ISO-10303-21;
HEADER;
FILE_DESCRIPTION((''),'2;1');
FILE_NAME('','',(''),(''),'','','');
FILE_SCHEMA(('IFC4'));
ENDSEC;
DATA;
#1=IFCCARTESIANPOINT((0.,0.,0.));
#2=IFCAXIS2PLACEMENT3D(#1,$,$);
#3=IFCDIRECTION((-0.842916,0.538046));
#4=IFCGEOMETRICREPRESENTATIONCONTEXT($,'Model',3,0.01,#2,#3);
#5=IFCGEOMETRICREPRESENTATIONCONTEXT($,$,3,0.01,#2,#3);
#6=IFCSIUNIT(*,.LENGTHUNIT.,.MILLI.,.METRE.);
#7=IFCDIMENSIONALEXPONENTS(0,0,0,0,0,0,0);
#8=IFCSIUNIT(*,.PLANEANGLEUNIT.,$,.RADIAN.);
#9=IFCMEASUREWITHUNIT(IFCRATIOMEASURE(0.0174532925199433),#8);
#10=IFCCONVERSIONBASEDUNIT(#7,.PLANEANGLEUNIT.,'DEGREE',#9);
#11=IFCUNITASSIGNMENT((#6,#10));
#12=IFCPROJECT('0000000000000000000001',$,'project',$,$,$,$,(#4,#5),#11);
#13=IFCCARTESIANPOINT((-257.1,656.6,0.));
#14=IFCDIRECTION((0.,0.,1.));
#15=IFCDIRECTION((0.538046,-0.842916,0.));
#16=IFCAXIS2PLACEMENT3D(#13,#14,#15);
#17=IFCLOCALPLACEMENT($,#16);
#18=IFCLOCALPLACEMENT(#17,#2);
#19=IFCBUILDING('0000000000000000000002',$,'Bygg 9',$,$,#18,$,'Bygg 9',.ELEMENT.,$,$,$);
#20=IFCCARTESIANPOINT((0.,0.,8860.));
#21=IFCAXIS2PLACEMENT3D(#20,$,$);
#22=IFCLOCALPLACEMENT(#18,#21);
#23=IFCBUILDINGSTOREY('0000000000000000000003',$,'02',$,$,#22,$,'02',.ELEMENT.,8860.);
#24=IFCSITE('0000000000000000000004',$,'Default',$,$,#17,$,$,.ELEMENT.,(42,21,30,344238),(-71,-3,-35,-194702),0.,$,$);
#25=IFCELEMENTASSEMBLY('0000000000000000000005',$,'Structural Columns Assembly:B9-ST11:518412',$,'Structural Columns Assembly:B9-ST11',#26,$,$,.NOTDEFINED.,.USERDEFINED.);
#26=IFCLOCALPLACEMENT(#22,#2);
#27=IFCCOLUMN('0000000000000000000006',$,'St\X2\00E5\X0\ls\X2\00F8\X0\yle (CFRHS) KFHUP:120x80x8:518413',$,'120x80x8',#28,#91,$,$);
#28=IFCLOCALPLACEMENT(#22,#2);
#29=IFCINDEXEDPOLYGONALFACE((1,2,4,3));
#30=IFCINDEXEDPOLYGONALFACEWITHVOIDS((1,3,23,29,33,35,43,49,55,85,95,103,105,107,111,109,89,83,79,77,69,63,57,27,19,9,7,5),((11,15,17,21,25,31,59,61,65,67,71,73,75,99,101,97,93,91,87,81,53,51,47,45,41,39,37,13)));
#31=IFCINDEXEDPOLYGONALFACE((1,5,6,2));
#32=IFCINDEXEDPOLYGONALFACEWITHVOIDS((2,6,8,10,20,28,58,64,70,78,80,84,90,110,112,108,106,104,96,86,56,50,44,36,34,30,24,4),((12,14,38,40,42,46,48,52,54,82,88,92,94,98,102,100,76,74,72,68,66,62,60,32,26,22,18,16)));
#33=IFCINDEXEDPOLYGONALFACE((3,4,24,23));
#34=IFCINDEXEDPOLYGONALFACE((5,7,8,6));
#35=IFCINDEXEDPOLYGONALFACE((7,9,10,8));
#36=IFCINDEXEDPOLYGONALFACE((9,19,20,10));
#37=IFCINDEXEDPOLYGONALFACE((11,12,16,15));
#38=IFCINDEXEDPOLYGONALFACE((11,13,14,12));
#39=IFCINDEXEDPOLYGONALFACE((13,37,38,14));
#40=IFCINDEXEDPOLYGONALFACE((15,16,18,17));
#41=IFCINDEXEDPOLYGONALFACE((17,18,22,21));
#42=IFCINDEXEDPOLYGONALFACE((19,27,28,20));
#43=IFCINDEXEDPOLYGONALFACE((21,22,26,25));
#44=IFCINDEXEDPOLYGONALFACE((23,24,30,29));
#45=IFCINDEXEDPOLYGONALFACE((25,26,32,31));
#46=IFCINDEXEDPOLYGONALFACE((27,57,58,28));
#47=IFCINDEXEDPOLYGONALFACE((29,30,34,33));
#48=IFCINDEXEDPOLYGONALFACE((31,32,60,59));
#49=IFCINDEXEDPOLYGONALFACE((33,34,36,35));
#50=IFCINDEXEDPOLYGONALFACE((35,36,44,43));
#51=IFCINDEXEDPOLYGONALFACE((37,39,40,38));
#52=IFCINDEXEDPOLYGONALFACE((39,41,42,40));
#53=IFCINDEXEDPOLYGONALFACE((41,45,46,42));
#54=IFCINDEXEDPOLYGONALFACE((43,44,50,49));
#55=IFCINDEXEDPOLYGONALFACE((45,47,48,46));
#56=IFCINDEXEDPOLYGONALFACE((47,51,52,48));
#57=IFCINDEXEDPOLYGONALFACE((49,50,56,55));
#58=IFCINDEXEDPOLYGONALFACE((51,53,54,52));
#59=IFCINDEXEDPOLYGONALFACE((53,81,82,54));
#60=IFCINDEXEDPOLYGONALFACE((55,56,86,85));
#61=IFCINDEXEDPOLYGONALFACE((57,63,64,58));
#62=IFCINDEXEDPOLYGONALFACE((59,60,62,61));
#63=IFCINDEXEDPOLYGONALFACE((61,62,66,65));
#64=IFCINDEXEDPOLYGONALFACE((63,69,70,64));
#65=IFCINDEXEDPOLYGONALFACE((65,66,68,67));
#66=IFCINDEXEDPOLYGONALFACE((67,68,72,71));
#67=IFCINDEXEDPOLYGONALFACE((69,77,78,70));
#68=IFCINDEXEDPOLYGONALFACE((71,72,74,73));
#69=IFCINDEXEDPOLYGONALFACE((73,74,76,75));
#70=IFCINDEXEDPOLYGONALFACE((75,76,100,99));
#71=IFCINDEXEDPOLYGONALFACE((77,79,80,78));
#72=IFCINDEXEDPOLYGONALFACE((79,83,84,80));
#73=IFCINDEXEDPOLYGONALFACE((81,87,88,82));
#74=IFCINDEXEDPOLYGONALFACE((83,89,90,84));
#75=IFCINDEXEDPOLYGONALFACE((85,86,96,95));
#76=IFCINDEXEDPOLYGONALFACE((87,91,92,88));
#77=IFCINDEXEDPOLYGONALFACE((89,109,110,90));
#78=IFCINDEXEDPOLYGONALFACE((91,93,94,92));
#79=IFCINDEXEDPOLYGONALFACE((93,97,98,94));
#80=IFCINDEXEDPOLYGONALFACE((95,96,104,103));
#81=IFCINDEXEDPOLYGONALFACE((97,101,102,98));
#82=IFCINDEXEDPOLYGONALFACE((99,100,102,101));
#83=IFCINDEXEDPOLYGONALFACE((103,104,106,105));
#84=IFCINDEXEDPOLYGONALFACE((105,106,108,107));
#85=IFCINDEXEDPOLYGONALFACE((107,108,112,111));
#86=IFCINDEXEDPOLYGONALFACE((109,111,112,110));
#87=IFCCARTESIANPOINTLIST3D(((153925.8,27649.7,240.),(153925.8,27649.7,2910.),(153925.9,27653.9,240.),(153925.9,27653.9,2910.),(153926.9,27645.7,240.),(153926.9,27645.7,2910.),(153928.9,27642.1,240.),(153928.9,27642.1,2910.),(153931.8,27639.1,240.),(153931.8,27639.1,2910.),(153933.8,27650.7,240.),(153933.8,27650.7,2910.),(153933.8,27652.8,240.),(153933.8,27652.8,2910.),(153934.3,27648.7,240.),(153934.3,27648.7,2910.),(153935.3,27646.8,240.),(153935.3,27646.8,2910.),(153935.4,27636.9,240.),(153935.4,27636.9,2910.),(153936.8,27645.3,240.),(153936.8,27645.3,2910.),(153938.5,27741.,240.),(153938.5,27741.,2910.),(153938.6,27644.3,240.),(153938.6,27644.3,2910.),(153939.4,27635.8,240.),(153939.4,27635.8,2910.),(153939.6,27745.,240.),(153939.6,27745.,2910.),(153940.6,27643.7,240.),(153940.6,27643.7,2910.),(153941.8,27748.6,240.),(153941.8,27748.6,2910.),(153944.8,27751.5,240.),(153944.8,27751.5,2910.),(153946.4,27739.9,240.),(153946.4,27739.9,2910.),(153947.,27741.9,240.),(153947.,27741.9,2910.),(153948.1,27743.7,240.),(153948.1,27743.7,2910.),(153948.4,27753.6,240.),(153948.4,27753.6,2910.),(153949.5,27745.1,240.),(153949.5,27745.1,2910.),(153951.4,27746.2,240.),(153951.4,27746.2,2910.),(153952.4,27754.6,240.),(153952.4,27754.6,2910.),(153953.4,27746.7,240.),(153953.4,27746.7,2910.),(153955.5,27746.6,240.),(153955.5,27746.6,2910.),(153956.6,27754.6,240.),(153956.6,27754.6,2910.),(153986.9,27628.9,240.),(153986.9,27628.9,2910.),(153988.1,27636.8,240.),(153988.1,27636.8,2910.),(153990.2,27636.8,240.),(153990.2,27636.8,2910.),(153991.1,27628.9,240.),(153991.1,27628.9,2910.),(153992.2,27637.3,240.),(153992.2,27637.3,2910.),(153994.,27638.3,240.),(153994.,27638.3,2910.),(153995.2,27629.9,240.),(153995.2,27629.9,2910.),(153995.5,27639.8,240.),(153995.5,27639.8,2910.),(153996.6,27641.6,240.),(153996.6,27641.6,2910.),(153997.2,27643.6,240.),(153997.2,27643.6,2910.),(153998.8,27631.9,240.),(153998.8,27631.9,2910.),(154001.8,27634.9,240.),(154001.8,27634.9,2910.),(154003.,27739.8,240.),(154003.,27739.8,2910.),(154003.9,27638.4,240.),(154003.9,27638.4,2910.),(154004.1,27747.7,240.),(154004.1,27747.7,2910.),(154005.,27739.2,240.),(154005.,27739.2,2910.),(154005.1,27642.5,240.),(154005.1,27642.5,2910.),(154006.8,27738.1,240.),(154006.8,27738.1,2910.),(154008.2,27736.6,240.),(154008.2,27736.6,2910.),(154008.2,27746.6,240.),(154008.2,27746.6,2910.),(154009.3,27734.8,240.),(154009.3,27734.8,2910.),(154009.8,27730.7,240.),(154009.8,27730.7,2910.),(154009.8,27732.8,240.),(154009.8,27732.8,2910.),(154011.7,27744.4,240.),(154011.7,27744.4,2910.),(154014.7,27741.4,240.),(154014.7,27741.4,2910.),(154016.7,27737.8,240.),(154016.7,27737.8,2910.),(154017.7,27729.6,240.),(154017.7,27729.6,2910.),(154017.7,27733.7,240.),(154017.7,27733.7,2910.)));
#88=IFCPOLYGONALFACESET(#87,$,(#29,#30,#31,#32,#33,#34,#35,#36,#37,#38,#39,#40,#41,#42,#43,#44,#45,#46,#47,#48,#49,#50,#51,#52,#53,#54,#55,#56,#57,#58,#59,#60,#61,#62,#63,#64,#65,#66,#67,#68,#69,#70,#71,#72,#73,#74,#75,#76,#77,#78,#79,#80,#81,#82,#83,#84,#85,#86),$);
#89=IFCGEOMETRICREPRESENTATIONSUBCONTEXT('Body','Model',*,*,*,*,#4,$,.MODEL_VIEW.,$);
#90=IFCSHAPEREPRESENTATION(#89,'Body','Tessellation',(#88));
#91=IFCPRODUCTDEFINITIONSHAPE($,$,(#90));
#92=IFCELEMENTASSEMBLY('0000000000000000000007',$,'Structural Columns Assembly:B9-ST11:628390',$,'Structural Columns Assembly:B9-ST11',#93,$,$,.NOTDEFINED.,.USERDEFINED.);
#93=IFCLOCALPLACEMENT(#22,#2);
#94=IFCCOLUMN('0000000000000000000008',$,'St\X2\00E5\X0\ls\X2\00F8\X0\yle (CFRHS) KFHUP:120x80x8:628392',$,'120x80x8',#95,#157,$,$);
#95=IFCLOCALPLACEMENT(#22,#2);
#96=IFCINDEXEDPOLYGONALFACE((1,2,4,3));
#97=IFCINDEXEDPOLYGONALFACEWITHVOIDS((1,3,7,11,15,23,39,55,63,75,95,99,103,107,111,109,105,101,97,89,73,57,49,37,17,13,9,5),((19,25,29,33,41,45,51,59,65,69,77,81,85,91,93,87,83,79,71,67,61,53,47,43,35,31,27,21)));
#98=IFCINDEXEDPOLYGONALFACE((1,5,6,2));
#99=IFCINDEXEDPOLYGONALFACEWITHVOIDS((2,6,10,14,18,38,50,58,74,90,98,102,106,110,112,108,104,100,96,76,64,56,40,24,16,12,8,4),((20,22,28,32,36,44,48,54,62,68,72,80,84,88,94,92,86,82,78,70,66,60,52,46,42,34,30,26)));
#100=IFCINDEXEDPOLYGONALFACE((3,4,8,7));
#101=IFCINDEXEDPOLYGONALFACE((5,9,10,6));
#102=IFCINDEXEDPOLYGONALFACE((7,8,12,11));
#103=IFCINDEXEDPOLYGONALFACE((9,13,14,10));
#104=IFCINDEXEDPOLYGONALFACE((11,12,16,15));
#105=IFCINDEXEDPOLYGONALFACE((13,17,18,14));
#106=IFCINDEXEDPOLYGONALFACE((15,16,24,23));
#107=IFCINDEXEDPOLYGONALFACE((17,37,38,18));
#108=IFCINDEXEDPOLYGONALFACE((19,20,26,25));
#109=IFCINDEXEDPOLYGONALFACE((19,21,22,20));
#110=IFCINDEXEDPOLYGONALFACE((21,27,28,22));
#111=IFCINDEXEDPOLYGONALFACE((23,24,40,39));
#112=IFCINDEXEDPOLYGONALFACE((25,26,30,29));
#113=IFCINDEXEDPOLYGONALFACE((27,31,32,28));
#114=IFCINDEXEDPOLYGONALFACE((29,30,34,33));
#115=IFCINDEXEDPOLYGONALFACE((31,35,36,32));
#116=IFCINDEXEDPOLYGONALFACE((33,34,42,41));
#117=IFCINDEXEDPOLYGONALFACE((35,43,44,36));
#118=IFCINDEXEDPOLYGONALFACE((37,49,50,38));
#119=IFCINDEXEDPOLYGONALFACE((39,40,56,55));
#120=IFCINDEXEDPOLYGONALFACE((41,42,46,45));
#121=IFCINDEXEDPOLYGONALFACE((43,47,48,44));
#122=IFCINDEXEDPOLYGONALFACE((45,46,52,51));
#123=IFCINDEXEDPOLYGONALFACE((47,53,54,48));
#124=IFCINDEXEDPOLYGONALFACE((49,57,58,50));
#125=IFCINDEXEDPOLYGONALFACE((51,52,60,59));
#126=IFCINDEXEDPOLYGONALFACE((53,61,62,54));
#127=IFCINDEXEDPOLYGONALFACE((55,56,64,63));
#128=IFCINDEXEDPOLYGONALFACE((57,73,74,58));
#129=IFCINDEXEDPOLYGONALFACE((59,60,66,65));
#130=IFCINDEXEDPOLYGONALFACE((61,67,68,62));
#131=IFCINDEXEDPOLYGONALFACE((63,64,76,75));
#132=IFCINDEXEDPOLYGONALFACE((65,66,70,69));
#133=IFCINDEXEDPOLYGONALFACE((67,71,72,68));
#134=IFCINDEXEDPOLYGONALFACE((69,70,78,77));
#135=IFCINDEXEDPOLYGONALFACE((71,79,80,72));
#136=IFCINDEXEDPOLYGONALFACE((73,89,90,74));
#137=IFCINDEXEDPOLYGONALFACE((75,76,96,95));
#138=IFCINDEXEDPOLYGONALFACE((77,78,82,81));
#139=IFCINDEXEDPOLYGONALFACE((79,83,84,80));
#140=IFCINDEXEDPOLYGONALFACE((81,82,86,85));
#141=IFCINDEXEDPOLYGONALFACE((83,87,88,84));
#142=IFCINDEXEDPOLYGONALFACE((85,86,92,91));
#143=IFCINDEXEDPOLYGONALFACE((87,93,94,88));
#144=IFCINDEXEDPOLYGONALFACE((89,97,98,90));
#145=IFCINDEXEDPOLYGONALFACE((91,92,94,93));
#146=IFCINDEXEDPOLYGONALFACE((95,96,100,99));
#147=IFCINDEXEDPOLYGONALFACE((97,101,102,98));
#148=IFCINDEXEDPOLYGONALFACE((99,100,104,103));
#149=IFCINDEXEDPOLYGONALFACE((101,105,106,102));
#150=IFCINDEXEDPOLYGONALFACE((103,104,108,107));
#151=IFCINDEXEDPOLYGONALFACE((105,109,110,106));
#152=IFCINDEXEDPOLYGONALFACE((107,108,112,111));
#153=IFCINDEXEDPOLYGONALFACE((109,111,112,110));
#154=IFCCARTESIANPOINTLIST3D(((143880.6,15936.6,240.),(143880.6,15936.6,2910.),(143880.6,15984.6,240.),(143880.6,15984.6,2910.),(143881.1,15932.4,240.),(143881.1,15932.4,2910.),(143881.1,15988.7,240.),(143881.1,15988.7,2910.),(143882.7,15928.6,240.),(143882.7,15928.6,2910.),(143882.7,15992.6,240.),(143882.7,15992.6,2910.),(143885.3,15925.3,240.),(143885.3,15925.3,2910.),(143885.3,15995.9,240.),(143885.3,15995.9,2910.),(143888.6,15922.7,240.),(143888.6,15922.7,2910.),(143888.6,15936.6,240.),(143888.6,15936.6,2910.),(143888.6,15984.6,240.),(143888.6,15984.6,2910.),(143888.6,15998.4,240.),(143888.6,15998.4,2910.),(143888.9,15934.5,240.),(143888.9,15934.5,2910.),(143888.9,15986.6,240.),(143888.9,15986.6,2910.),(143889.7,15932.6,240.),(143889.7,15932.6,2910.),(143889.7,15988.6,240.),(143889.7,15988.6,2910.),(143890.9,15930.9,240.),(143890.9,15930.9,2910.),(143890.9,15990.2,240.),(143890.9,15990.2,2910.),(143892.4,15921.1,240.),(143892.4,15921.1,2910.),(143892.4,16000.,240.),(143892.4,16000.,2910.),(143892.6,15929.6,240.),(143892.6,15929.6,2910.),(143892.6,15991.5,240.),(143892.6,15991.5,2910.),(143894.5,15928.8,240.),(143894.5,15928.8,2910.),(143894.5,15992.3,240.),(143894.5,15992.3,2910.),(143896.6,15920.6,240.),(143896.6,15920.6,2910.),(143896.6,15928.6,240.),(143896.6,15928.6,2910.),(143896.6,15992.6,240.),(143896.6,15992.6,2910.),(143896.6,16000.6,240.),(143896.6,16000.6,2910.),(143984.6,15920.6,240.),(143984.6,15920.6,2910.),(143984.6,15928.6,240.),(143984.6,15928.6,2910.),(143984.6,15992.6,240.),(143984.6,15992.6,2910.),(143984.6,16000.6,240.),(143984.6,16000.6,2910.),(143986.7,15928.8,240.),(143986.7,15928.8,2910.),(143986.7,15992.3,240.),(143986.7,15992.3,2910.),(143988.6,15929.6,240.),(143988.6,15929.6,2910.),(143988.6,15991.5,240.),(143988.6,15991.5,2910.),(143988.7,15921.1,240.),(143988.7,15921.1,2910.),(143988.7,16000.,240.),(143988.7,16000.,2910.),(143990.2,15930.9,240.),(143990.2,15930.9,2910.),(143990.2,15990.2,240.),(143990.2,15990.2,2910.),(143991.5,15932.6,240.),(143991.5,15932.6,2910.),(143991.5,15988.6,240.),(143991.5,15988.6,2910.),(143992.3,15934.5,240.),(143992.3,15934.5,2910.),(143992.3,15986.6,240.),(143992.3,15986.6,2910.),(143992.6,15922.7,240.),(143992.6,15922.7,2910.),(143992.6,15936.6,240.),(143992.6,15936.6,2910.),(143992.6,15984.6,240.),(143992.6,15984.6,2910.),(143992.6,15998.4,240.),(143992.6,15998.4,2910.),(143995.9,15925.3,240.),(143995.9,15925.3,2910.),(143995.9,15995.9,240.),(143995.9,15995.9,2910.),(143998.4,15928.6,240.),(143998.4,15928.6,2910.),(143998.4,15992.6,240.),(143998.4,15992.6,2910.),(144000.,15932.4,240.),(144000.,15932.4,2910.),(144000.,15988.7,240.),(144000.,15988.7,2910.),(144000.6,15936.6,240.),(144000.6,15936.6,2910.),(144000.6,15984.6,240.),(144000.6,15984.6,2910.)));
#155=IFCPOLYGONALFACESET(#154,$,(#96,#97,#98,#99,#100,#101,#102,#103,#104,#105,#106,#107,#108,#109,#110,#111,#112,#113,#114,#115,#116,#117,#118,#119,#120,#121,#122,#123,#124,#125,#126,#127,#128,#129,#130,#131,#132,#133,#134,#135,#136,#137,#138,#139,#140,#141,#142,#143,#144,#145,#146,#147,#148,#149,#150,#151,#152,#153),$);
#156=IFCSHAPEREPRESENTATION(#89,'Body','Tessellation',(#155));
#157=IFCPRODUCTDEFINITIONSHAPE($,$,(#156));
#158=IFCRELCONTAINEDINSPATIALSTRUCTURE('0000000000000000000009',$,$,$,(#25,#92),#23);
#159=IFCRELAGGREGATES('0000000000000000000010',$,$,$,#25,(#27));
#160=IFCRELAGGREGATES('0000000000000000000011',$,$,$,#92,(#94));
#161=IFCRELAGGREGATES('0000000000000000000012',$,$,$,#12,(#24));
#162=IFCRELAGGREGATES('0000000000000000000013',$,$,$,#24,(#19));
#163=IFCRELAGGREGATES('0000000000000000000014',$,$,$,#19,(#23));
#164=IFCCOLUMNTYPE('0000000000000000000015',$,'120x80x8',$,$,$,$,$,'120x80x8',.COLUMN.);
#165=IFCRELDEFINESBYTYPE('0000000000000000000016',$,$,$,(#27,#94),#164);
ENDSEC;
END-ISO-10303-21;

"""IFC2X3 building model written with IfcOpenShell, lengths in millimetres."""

from ifc_helpers import new_model, entity, si_unit, converted_unit, direction, frame, frame_2d, origin, place, context, subcontext, project, spatial, polyline, circle_curve, parameter, trimmed, segment, composite_curve, outline, extrude, source, transform, mapped, type_object, type_shapes, element, aggregate, save


model = new_model("IFC2X3")

# Units and contexts
model_context = context("Model", 3, precision=0.01, world=origin(), true_north=direction((-0.842916, 0.538046)))
context_of_model = context(None, 3, precision=0.01, world=origin(), true_north=direction((-0.842916, 0.538046)))
body_context = subcontext(model_context, "Body", "Model", "MODEL_VIEW")
ifc_project = project(units=[si_unit("LENGTHUNIT", "METRE", prefix="MILLI"), converted_unit("PLANEANGLEUNIT", "DEGREE", entity("IfcRatioMeasure", 0.0174532925199433), si_unit("PLANEANGLEUNIT", "RADIAN"), dimensions=[0, 0, 0, 0, 0, 0, 0])], contexts=[model_context, context_of_model])

# Site, building, storey
site_placement = place(None, frame((-257.1, 656.6, 0.0), z_axis=(0.0, 0.0, 1.0), x_axis=(0.538046, -0.842916, 0.0)))
site = spatial("IfcSite", under=ifc_project, at=site_placement, Name="Default", CompositionType="ELEMENT", RefLatitude=(42, 21, 30, 344238), RefLongitude=(-71, -3, -35, -194702), RefElevation=0.0)
building_placement = place(site_placement, origin())
building = spatial("IfcBuilding", under=site, at=building_placement, Name="Bygg 9", LongName="Bygg 9", CompositionType="ELEMENT")
storey_placement = place(building_placement, frame((0.0, 0.0, 8860.0)))
storey = spatial("IfcBuildingStorey", under=building, at=storey_placement, Name="02", LongName="02", CompositionType="ELEMENT", Elevation=8860.0)

# Element assemblies, columns
column_type = type_object("IfcColumnType", Name="120x80x8", ElementType="120x80x8", PredefinedType="COLUMN")
shared_shape_1 = source(origin(), body_context, "Body", "SweptSolid", [
    extrude(outline(composite_curve([segment(trimmed(circle_curve(frame_2d((-24.0, 44.0), x_axis=(1.0, 0.0)), 16.0), [parameter(90.0)], [parameter(180.0)], True, "PARAMETER"), True, "CONTINUOUS"), segment(polyline([(-40.0, 44.0), (-40.0, -44.0)]), True, "CONTINUOUS"), segment(trimmed(circle_curve(frame_2d((-24.0, -44.0), x_axis=(1.0, 0.0)), 16.0), [parameter(180.0)], [parameter(270.0)], True, "PARAMETER"), True, "CONTINUOUS"), segment(polyline([(-24.0, -60.0), (24.0, -60.0)]), True, "CONTINUOUS"), segment(trimmed(circle_curve(frame_2d((24.0, -44.0), x_axis=(1.0, 0.0)), 16.0), [parameter(270.0)], [parameter(0.0)], True, "PARAMETER"), True, "CONTINUOUS"), segment(polyline([(40.0, -44.0), (40.0, 44.0)]), True, "CONTINUOUS"), segment(trimmed(circle_curve(frame_2d((24.0, 44.0), x_axis=(1.0, 0.0)), 16.0), [parameter(0.0)], [parameter(90.0)], True, "PARAMETER"), True, "CONTINUOUS"), segment(polyline([(24.0, 60.0), (-24.0, 60.0)]), True, "CONTINUOUS")], self_intersect=False), holes=[composite_curve([segment(polyline([(-24.0, 52.0), (24.0, 52.0)]), True, "CONTINUOUS"), segment(trimmed(circle_curve(frame_2d((24.0, 44.0), x_axis=(1.0, 0.0)), 8.0), [parameter(360.0)], [parameter(90.0)], True, "PARAMETER"), False, "CONTINUOUS"), segment(polyline([(32.0, 44.0), (32.0, -44.0)]), True, "CONTINUOUS"), segment(trimmed(circle_curve(frame_2d((24.0, -44.0), x_axis=(1.0, 0.0)), 8.0), [parameter(270.0)], [parameter(360.0)], True, "PARAMETER"), False, "CONTINUOUS"), segment(polyline([(24.0, -52.0), (-24.0, -52.0)]), True, "CONTINUOUS"), segment(trimmed(circle_curve(frame_2d((-24.0, -44.0), x_axis=(1.0, 0.0)), 8.0), [parameter(180.0)], [parameter(270.0)], True, "PARAMETER"), False, "CONTINUOUS"), segment(polyline([(-32.0, -44.0), (-32.0, 44.0)]), True, "CONTINUOUS"), segment(trimmed(circle_curve(frame_2d((-24.0, 44.0), x_axis=(1.0, 0.0)), 8.0), [parameter(90.0)], [parameter(180.0)], True, "PARAMETER"), False, "CONTINUOUS")], self_intersect=False)]), frame((41.6, 61.6, 0.0), z_axis=(0.0, 0.0, 1.0), x_axis=(-1.0, 0.0, 0.0)), (0.0, 0.0, 1.0), 2670.0),
])
type_shapes(column_type, [shared_shape_1])
assembly_1_placement = place(storey_placement, origin())
assembly_1 = element("IfcElementAssembly", 1, at=assembly_1_placement, inside=storey, Name="Structural Columns Assembly:B9-ST11:518412", ObjectType="Structural Columns Assembly:B9-ST11", AssemblyPlace="NOTDEFINED", PredefinedType="USERDEFINED")
column_1_placement = place(assembly_1_placement, frame((154021.8, 27746.7, 240.0), z_axis=(0.0, 0.0, 1.0), x_axis=(-0.989691, 0.143216, 0.0)))
column_1 = element("IfcColumn", 2, at=column_1_placement, type_object=column_type, Name="Stålsøyle (CFRHS) KFHUP:120x80x8:518413", ObjectType="120x80x8", context=body_context, shape_type="MappedRepresentation", body=[
    mapped(shared_shape_1, transform((0.0, 0.0, 0.0), scale=1.0)),
])
assembly_2_placement = place(storey_placement, origin())
assembly_2 = element("IfcElementAssembly", 3, at=assembly_2_placement, inside=storey, Name="Structural Columns Assembly:B9-ST11:628390", ObjectType="Structural Columns Assembly:B9-ST11", AssemblyPlace="NOTDEFINED", PredefinedType="USERDEFINED")
column_2_placement = place(assembly_2_placement, frame((144002.2, 15919.0, 240.0), z_axis=(0.0, 0.0, 1.0), x_axis=(0.0, 1.0, 0.0)))
column_2 = element("IfcColumn", 4, at=column_2_placement, type_object=column_type, Name="Stålsøyle (CFRHS) KFHUP:120x80x8:628392", ObjectType="120x80x8", context=body_context, shape_type="MappedRepresentation", body=[
    mapped(shared_shape_1, transform((0.0, 0.0, 0.0), scale=1.0)),
])

aggregate(assembly_1, [column_1])
aggregate(assembly_2, [column_2])

save(model, "model.ifc")
